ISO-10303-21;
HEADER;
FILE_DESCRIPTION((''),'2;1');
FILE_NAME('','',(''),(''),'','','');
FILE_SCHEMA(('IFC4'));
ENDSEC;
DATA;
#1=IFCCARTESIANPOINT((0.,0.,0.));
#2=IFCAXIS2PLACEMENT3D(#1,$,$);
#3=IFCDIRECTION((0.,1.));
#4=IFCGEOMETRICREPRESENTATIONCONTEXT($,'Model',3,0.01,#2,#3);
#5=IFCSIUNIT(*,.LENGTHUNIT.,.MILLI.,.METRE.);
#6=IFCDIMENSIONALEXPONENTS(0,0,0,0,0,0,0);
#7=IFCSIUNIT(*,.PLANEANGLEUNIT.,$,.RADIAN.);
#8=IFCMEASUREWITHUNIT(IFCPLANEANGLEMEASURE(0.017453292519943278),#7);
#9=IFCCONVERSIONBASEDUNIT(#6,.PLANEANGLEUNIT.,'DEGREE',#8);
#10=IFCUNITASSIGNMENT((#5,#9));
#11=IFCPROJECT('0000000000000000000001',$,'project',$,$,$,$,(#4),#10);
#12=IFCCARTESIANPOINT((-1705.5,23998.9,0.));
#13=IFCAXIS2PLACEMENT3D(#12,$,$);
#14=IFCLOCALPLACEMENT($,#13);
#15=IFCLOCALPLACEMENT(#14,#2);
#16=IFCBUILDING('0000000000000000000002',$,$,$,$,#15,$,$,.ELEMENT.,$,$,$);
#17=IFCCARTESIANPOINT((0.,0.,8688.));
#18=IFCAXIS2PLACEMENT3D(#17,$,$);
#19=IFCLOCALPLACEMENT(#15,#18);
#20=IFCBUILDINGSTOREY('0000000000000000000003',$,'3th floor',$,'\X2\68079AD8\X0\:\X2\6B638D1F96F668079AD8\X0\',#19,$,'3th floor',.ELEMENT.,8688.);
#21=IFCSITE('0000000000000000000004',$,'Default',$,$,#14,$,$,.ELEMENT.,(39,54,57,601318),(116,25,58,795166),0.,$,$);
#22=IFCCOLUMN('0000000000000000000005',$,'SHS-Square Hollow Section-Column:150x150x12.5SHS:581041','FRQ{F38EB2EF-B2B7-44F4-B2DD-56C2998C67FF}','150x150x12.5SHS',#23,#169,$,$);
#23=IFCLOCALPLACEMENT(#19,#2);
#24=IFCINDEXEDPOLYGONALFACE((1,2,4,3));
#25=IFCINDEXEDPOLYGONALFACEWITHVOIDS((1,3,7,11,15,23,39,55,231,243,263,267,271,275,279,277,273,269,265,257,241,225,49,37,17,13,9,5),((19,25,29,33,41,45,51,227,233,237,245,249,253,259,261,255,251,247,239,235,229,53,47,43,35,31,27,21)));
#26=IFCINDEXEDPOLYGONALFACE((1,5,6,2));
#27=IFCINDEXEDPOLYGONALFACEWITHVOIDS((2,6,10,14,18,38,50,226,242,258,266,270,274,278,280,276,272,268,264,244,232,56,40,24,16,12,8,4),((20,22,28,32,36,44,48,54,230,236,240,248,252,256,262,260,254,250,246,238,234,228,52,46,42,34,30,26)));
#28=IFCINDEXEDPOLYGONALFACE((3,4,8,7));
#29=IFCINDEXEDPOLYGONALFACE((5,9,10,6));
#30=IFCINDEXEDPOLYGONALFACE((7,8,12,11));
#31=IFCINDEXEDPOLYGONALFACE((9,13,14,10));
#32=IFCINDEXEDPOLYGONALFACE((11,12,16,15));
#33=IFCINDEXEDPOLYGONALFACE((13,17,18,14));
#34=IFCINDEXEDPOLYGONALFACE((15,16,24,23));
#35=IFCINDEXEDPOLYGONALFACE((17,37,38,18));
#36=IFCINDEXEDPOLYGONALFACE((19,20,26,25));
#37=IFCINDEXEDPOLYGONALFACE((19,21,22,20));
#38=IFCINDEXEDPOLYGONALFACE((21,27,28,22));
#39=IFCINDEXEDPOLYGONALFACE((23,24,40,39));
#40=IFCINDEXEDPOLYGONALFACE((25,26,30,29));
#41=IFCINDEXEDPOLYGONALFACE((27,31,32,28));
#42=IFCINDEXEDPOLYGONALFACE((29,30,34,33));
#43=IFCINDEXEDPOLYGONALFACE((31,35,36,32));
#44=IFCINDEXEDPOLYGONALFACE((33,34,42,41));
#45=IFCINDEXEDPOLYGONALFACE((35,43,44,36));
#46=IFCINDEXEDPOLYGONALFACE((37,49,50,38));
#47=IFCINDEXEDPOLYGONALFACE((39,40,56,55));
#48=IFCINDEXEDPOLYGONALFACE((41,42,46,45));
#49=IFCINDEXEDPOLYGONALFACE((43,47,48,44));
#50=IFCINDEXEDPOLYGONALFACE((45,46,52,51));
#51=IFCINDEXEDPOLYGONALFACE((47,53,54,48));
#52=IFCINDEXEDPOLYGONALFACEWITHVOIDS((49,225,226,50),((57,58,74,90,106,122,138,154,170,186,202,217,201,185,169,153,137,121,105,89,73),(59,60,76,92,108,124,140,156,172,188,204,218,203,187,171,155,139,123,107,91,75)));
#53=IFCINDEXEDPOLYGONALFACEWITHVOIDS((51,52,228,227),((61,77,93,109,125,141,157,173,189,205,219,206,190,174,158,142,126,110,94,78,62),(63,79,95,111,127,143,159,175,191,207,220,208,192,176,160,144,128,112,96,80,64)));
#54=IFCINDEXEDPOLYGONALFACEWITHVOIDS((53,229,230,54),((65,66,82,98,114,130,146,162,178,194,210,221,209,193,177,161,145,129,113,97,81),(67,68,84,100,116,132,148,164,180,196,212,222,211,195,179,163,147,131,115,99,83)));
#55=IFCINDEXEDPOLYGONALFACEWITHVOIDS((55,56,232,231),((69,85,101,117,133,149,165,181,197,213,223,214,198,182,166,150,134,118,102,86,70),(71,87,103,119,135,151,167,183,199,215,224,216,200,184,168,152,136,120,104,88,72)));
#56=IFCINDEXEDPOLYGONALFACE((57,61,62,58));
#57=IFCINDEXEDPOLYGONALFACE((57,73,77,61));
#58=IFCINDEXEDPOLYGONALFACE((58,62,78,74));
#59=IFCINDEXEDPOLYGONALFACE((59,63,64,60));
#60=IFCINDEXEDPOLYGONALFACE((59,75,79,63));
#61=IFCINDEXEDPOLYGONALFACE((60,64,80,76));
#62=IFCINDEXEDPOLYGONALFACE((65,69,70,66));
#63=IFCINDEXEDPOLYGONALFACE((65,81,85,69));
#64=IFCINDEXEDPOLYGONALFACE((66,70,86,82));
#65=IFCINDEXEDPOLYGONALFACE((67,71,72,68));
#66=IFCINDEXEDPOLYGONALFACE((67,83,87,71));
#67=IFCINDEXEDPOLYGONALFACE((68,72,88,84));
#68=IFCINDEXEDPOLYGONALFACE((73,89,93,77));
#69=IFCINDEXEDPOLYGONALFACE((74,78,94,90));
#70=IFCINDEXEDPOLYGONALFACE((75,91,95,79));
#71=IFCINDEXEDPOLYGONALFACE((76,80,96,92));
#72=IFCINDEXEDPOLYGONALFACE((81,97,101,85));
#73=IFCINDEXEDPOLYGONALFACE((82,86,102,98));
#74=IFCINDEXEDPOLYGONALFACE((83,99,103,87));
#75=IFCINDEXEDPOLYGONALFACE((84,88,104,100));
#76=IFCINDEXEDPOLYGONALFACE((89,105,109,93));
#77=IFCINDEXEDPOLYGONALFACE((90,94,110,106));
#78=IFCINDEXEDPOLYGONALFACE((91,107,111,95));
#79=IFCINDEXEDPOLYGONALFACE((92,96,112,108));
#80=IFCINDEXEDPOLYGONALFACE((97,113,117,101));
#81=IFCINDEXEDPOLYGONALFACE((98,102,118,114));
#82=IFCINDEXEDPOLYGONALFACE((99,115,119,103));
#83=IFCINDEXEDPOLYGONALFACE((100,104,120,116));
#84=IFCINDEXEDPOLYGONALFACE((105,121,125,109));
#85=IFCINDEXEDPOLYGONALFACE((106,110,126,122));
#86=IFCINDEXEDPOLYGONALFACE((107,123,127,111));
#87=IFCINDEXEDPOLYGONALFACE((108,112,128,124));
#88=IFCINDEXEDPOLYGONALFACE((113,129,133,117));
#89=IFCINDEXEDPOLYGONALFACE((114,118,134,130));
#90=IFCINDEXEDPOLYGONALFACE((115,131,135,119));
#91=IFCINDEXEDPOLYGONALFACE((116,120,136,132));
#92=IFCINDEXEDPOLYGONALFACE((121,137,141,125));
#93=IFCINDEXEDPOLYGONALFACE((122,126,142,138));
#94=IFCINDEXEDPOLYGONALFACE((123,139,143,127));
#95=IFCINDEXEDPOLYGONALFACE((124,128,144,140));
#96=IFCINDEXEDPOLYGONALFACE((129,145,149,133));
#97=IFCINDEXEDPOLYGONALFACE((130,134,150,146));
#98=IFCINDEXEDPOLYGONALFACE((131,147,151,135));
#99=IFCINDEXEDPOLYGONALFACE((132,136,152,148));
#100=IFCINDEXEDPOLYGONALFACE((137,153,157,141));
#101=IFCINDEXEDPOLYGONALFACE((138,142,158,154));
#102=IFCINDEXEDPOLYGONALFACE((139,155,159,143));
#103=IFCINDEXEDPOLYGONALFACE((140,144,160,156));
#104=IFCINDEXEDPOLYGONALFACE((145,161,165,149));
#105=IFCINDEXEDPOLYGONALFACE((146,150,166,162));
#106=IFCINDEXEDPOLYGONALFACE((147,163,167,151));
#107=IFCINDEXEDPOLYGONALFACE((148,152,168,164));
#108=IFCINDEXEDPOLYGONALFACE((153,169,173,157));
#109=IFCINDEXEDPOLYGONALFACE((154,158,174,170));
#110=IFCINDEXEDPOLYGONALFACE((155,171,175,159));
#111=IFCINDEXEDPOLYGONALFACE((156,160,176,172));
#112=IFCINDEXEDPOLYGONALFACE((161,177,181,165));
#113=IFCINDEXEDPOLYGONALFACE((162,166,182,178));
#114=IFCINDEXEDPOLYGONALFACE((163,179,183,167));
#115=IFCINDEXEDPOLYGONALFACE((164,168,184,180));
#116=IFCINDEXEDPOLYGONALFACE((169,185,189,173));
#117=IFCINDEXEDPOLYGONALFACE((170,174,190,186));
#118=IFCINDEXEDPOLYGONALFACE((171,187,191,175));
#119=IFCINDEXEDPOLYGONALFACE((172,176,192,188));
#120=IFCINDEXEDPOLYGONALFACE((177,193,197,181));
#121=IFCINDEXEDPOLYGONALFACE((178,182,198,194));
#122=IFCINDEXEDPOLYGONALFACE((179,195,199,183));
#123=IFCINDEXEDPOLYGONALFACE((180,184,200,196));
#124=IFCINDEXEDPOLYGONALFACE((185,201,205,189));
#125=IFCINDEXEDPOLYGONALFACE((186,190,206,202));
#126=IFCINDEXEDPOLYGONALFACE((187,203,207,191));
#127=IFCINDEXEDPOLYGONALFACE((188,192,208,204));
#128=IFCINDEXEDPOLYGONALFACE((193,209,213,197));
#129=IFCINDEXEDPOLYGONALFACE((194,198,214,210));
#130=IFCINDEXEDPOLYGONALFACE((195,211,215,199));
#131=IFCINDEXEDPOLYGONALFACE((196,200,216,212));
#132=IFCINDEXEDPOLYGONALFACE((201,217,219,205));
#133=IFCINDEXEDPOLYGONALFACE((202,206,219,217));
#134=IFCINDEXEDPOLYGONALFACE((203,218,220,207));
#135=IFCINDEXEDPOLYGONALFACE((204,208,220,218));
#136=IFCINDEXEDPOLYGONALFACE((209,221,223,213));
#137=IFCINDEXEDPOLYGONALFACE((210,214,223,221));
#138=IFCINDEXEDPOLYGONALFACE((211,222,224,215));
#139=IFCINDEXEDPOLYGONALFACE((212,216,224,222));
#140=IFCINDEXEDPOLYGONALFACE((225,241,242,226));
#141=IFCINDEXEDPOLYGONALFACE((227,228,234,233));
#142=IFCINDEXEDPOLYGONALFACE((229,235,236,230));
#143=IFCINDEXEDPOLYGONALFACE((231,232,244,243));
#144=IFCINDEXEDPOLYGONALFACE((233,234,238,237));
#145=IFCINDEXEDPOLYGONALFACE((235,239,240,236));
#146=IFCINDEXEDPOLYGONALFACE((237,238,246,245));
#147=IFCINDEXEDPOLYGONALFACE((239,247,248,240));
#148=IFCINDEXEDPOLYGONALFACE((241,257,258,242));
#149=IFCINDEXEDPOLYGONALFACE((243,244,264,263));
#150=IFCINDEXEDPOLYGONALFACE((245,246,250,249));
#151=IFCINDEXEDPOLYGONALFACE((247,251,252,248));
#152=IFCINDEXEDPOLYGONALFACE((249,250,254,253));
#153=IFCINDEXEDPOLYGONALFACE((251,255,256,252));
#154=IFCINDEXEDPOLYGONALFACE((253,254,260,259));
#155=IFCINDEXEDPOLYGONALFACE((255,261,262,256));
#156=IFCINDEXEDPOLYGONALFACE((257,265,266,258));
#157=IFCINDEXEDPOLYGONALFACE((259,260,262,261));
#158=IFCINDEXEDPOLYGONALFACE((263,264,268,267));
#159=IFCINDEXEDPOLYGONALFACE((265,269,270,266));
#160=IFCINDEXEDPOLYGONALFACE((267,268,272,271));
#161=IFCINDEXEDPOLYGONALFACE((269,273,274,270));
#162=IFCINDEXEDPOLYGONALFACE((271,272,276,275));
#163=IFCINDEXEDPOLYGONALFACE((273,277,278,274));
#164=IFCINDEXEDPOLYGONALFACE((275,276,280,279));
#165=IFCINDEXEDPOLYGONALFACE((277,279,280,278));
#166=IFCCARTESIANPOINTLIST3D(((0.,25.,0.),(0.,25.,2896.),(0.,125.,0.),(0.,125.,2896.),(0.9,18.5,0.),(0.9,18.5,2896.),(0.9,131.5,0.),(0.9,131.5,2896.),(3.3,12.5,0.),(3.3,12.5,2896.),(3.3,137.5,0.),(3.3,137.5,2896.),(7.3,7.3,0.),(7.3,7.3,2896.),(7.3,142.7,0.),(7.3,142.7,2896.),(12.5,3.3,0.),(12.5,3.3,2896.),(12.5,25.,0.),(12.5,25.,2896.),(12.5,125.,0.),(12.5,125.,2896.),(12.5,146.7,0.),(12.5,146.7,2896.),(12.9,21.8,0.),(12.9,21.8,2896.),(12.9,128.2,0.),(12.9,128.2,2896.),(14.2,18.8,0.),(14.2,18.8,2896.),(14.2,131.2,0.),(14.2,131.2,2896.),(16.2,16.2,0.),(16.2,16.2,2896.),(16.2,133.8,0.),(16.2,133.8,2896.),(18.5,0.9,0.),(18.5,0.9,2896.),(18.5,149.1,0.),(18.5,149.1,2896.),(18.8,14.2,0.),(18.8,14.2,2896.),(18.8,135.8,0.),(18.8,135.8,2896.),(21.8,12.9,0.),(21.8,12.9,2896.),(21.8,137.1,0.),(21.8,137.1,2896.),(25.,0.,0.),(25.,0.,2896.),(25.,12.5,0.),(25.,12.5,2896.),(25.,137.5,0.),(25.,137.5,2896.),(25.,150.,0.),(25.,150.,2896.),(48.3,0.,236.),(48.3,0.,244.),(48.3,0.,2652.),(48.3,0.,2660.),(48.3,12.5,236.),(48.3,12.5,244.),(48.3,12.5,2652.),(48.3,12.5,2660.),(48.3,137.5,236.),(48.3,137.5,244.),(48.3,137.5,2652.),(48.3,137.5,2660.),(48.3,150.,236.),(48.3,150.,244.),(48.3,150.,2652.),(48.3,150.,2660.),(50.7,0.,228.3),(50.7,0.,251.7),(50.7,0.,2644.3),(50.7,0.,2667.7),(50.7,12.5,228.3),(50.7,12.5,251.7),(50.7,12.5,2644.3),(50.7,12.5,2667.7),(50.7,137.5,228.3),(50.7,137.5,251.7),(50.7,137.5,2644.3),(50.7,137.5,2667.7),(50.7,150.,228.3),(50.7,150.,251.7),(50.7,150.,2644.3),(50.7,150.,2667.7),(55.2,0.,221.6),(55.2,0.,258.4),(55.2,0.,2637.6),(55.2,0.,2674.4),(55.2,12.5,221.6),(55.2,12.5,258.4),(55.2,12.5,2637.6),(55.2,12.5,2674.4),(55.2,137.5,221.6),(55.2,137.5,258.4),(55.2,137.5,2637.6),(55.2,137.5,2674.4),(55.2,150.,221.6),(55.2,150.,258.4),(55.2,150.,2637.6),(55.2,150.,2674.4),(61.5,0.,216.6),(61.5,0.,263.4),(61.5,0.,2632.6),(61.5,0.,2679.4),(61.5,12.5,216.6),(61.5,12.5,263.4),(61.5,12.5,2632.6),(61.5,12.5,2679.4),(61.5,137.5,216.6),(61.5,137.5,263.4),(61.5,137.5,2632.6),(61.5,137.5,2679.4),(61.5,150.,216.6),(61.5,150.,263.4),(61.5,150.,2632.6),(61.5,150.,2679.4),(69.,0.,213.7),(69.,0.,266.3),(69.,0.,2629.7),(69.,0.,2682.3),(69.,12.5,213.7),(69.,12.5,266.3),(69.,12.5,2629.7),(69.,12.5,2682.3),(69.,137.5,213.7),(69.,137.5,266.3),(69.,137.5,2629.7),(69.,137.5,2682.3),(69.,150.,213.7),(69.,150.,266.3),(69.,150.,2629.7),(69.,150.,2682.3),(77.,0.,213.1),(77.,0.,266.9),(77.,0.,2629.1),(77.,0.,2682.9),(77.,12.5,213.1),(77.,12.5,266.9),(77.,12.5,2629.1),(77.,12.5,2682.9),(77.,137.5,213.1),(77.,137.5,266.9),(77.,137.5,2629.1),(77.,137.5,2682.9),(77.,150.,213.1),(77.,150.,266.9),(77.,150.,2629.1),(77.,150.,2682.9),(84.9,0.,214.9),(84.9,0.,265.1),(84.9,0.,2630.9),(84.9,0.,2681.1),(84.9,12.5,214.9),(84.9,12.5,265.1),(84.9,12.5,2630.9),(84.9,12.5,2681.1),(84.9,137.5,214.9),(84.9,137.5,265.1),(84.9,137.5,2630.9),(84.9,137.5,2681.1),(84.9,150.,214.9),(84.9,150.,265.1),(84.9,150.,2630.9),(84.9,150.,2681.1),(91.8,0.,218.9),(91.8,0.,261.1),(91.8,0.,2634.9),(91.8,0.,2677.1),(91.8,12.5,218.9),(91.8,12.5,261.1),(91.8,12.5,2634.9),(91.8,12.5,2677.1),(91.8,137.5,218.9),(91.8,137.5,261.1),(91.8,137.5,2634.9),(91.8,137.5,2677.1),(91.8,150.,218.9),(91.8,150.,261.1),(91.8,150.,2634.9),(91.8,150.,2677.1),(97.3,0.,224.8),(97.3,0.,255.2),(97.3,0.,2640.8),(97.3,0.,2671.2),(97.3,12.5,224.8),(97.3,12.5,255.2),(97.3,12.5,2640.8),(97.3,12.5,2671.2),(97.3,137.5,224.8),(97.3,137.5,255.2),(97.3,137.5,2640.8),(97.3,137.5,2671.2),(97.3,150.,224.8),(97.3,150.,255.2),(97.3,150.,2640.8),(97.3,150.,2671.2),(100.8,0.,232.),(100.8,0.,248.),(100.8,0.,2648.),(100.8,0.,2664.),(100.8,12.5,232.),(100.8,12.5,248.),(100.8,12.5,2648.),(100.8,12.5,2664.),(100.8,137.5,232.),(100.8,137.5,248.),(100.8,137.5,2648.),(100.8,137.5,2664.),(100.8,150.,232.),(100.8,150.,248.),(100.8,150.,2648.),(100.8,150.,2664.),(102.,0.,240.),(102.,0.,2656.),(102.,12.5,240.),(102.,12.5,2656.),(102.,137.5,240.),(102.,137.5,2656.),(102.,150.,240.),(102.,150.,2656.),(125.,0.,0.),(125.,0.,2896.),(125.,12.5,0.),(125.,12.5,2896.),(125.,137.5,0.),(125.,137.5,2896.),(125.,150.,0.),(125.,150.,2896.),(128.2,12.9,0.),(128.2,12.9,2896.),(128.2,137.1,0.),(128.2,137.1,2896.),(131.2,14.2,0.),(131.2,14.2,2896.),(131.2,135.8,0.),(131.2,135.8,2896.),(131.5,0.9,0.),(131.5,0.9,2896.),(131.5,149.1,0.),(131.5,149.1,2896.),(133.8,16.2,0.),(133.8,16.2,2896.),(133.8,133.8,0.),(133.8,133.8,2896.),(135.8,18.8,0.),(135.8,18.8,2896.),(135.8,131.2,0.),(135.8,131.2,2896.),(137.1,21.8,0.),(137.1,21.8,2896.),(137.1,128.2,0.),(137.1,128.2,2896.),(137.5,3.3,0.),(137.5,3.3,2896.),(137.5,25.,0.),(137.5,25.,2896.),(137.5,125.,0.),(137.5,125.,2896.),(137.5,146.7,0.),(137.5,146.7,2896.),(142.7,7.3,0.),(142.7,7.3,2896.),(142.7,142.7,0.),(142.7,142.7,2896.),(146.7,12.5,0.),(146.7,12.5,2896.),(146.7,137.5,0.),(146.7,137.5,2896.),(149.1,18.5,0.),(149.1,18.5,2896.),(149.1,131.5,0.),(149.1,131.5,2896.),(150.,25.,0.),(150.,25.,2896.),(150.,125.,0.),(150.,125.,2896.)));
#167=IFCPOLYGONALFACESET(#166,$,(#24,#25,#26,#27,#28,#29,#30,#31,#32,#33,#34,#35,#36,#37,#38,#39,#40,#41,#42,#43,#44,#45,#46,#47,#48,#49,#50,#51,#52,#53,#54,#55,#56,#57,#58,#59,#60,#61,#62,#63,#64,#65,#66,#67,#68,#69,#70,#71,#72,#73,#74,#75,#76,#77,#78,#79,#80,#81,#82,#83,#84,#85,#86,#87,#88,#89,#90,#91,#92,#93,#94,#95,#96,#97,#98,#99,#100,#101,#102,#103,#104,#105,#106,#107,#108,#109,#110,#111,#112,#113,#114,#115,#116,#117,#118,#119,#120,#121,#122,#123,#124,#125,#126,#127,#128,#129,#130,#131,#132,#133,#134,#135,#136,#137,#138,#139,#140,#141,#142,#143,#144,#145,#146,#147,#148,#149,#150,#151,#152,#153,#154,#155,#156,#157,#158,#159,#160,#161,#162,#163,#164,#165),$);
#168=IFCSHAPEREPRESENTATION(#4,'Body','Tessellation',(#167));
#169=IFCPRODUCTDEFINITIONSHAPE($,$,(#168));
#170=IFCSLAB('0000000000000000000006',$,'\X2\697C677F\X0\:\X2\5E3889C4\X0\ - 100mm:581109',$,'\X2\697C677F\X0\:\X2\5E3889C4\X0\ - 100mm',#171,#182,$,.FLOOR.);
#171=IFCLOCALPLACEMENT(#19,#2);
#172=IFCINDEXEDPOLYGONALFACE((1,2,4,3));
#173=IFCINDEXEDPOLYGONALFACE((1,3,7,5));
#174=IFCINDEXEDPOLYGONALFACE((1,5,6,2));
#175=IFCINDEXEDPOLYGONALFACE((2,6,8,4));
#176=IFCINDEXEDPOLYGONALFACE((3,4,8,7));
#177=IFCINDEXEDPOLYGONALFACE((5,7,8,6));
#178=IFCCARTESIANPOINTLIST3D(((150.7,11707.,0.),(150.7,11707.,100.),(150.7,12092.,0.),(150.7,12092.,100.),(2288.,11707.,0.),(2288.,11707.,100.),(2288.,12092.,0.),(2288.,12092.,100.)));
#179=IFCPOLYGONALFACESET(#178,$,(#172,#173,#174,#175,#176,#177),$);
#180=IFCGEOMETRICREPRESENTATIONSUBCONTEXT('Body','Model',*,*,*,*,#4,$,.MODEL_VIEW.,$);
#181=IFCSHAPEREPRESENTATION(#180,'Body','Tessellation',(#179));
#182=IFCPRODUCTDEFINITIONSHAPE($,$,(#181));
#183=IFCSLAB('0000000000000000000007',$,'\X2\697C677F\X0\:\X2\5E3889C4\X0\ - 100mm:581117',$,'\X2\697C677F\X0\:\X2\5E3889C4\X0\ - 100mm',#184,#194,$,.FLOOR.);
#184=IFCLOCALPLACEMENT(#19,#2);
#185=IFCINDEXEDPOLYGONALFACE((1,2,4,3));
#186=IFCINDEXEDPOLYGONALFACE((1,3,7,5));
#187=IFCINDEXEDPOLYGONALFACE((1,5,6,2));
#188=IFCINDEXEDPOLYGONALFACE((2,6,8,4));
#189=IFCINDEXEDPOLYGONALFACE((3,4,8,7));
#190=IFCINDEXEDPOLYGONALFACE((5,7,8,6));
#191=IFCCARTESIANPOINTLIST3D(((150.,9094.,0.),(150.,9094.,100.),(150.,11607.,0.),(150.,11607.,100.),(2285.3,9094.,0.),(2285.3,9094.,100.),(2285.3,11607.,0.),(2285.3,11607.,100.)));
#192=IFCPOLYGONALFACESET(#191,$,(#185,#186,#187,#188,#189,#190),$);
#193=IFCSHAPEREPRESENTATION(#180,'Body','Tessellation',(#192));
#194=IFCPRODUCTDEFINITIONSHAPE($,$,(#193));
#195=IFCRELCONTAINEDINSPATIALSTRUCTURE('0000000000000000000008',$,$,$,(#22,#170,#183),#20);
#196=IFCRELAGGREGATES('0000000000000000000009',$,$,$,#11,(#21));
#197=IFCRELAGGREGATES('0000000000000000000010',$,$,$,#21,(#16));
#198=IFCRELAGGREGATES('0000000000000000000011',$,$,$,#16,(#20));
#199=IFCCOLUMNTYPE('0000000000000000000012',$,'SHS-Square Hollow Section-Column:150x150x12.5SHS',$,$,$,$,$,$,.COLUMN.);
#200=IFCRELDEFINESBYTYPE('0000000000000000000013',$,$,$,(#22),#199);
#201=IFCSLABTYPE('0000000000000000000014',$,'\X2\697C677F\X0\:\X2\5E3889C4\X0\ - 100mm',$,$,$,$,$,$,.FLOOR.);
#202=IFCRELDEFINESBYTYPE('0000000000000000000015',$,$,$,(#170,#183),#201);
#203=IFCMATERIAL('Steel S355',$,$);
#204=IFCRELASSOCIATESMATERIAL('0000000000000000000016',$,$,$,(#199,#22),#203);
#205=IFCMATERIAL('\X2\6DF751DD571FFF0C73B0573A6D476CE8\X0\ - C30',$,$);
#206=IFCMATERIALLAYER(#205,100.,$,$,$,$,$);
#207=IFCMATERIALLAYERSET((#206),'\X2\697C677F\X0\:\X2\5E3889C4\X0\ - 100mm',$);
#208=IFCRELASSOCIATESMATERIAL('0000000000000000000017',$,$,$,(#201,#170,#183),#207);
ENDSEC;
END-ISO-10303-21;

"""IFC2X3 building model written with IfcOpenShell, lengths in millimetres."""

from ifc_helpers import new_model, entity, si_unit, converted_unit, direction, frame, frame_2d, origin, origin_2d, origin_2d_with_axis, place, context, subcontext, project, spatial, circle_curve, rectangle, hollow_rectangle, outline, extrude, material, layer, layer_set, layer_usage, type_object, element, save


model = new_model("IFC2X3")

# Units and contexts
model_context = context("Model", 3, precision=0.01, world=origin(), true_north=direction((0.0, 1.0)))
body_context = subcontext(model_context, "Body", "Model", "MODEL_VIEW")
ifc_project = project(units=[si_unit("LENGTHUNIT", "METRE", prefix="MILLI"), converted_unit("PLANEANGLEUNIT", "DEGREE", entity("IfcPlaneAngleMeasure", 0.017453292519943278), si_unit("PLANEANGLEUNIT", "RADIAN"), dimensions=[0, 0, 0, 0, 0, 0, 0])], contexts=[model_context])

# Site, building, storey
site_placement = place(None, frame((-1705.5, 23998.9, 0.0)))
site = spatial("IfcSite", under=ifc_project, at=site_placement, Name="Default", CompositionType="ELEMENT", RefLatitude=(39, 54, 57, 601318), RefLongitude=(116, 25, 58, 795166), RefElevation=0.0)
building_placement = place(site_placement, origin())
building = spatial("IfcBuilding", under=site, at=building_placement, CompositionType="ELEMENT")
storey_placement = place(building_placement, frame((0.0, 0.0, 8688.0)))
storey = spatial("IfcBuildingStorey", under=building, at=storey_placement, Name="3th floor", ObjectType="标高:正负零标高", LongName="3th floor", CompositionType="ELEMENT", Elevation=8688.0)

# Column, openings
ifc_material_1 = material(Name="Steel S355")
column_type_1 = type_object("IfcColumnType", Name="SHS-Square Hollow Section-Column:150x150x12.5SHS", PredefinedType="COLUMN", material=ifc_material_1)
column_1_placement = place(storey_placement, frame((75.0, 75.0, 2896.0), z_axis=(0.0, 0.0, 1.0), x_axis=(0.0, -1.0, 0.0)))
column_1 = element("IfcColumn", 1, at=column_1_placement, inside=storey, type_object=column_type_1, material=ifc_material_1, Name="SHS-Square Hollow Section-Column:150x150x12.5SHS:581041", Description="FRQ{F38EB2EF-B2B7-44F4-B2DD-56C2998C67FF}", ObjectType="150x150x12.5SHS", context=model_context, shape_type="SweptSolid", body=[
    extrude(hollow_rectangle(XDim=150.0, YDim=150.0, WallThickness=12.5, InnerFilletRadius=12.5, OuterFilletRadius=25.0, at=origin_2d()), origin(), (0.0, 0.0, -1.0), 2896.0),
])
opening_1_placement = place(column_1_placement, frame((-175.1, 0.0, -2896.0), z_axis=(1.0, 0.0, 0.0), x_axis=(0.0, 1.0, 0.0)))
element("IfcOpeningElement", 2, at=opening_1_placement, cuts=column_1, ObjectType="Opening", context=model_context, shape_type="SweptSolid", body=[
    extrude(outline(circle_curve(frame_2d((0.0, 240.0), x_axis=(1.0, 0.0)), 27.0)), origin(), (0.0, 0.0, 1.0), 350.2),
])
opening_2_placement = place(column_1_placement, frame((-175.1, 0.0, 0.0), z_axis=(1.0, 0.0, 0.0), x_axis=(0.0, 1.0, 0.0)))
element("IfcOpeningElement", 3, at=opening_2_placement, cuts=column_1, ObjectType="Opening", context=model_context, shape_type="SweptSolid", body=[
    extrude(outline(circle_curve(frame_2d((0.0, -240.0), x_axis=(1.0, 0.0)), 27.0)), origin(), (0.0, 0.0, 1.0), 350.2),
])

# Slabs
ifc_material_2 = material(Name="混凝土，现场浇注 - C30")
ifc_layer_1 = layer(ifc_material_2, 100.0)
ifc_layer_set_1 = layer_set([ifc_layer_1], Name="楼板:常规 - 100mm")
ifc_layer_usage_1 = layer_usage(ifc_layer_set_1, "AXIS3", "POSITIVE", 0.0)
slab_type_1 = type_object("IfcSlabType", Name="楼板:常规 - 100mm", PredefinedType="FLOOR", material=ifc_layer_set_1)
slab_1_placement = place(storey_placement, origin())
element("IfcSlab", 4, at=slab_1_placement, inside=storey, type_object=slab_type_1, material=ifc_layer_usage_1, Name="楼板:常规 - 100mm:581109", ObjectType="楼板:常规 - 100mm", PredefinedType="FLOOR", context=body_context, shape_type="SweptSolid", body=[
    extrude(rectangle(XDim=385.0, YDim=2137.3, at=origin_2d_with_axis()), frame((1219.3, 11899.5, 100.0), z_axis=(0.0, 0.0, -1.0), x_axis=(0.0, 1.0, 0.0)), (0.0, 0.0, 1.0), 100.0),
])
ifc_layer_usage_2 = layer_usage(ifc_layer_set_1, "AXIS3", "POSITIVE", 0.0)
slab_2_placement = place(storey_placement, origin())
element("IfcSlab", 5, at=slab_2_placement, inside=storey, type_object=slab_type_1, material=ifc_layer_usage_2, Name="楼板:常规 - 100mm:581117", ObjectType="楼板:常规 - 100mm", PredefinedType="FLOOR", context=body_context, shape_type="SweptSolid", body=[
    extrude(rectangle(XDim=2513.0, YDim=2135.3, at=frame_2d((0.0, 0.0), x_axis=(1.0, 0.0))), frame((1217.6, 10350.5, 100.0), z_axis=(0.0, 0.0, -1.0), x_axis=(0.0, 1.0, 0.0)), (0.0, 0.0, 1.0), 100.0),
])

save(model, "model.ifc")
